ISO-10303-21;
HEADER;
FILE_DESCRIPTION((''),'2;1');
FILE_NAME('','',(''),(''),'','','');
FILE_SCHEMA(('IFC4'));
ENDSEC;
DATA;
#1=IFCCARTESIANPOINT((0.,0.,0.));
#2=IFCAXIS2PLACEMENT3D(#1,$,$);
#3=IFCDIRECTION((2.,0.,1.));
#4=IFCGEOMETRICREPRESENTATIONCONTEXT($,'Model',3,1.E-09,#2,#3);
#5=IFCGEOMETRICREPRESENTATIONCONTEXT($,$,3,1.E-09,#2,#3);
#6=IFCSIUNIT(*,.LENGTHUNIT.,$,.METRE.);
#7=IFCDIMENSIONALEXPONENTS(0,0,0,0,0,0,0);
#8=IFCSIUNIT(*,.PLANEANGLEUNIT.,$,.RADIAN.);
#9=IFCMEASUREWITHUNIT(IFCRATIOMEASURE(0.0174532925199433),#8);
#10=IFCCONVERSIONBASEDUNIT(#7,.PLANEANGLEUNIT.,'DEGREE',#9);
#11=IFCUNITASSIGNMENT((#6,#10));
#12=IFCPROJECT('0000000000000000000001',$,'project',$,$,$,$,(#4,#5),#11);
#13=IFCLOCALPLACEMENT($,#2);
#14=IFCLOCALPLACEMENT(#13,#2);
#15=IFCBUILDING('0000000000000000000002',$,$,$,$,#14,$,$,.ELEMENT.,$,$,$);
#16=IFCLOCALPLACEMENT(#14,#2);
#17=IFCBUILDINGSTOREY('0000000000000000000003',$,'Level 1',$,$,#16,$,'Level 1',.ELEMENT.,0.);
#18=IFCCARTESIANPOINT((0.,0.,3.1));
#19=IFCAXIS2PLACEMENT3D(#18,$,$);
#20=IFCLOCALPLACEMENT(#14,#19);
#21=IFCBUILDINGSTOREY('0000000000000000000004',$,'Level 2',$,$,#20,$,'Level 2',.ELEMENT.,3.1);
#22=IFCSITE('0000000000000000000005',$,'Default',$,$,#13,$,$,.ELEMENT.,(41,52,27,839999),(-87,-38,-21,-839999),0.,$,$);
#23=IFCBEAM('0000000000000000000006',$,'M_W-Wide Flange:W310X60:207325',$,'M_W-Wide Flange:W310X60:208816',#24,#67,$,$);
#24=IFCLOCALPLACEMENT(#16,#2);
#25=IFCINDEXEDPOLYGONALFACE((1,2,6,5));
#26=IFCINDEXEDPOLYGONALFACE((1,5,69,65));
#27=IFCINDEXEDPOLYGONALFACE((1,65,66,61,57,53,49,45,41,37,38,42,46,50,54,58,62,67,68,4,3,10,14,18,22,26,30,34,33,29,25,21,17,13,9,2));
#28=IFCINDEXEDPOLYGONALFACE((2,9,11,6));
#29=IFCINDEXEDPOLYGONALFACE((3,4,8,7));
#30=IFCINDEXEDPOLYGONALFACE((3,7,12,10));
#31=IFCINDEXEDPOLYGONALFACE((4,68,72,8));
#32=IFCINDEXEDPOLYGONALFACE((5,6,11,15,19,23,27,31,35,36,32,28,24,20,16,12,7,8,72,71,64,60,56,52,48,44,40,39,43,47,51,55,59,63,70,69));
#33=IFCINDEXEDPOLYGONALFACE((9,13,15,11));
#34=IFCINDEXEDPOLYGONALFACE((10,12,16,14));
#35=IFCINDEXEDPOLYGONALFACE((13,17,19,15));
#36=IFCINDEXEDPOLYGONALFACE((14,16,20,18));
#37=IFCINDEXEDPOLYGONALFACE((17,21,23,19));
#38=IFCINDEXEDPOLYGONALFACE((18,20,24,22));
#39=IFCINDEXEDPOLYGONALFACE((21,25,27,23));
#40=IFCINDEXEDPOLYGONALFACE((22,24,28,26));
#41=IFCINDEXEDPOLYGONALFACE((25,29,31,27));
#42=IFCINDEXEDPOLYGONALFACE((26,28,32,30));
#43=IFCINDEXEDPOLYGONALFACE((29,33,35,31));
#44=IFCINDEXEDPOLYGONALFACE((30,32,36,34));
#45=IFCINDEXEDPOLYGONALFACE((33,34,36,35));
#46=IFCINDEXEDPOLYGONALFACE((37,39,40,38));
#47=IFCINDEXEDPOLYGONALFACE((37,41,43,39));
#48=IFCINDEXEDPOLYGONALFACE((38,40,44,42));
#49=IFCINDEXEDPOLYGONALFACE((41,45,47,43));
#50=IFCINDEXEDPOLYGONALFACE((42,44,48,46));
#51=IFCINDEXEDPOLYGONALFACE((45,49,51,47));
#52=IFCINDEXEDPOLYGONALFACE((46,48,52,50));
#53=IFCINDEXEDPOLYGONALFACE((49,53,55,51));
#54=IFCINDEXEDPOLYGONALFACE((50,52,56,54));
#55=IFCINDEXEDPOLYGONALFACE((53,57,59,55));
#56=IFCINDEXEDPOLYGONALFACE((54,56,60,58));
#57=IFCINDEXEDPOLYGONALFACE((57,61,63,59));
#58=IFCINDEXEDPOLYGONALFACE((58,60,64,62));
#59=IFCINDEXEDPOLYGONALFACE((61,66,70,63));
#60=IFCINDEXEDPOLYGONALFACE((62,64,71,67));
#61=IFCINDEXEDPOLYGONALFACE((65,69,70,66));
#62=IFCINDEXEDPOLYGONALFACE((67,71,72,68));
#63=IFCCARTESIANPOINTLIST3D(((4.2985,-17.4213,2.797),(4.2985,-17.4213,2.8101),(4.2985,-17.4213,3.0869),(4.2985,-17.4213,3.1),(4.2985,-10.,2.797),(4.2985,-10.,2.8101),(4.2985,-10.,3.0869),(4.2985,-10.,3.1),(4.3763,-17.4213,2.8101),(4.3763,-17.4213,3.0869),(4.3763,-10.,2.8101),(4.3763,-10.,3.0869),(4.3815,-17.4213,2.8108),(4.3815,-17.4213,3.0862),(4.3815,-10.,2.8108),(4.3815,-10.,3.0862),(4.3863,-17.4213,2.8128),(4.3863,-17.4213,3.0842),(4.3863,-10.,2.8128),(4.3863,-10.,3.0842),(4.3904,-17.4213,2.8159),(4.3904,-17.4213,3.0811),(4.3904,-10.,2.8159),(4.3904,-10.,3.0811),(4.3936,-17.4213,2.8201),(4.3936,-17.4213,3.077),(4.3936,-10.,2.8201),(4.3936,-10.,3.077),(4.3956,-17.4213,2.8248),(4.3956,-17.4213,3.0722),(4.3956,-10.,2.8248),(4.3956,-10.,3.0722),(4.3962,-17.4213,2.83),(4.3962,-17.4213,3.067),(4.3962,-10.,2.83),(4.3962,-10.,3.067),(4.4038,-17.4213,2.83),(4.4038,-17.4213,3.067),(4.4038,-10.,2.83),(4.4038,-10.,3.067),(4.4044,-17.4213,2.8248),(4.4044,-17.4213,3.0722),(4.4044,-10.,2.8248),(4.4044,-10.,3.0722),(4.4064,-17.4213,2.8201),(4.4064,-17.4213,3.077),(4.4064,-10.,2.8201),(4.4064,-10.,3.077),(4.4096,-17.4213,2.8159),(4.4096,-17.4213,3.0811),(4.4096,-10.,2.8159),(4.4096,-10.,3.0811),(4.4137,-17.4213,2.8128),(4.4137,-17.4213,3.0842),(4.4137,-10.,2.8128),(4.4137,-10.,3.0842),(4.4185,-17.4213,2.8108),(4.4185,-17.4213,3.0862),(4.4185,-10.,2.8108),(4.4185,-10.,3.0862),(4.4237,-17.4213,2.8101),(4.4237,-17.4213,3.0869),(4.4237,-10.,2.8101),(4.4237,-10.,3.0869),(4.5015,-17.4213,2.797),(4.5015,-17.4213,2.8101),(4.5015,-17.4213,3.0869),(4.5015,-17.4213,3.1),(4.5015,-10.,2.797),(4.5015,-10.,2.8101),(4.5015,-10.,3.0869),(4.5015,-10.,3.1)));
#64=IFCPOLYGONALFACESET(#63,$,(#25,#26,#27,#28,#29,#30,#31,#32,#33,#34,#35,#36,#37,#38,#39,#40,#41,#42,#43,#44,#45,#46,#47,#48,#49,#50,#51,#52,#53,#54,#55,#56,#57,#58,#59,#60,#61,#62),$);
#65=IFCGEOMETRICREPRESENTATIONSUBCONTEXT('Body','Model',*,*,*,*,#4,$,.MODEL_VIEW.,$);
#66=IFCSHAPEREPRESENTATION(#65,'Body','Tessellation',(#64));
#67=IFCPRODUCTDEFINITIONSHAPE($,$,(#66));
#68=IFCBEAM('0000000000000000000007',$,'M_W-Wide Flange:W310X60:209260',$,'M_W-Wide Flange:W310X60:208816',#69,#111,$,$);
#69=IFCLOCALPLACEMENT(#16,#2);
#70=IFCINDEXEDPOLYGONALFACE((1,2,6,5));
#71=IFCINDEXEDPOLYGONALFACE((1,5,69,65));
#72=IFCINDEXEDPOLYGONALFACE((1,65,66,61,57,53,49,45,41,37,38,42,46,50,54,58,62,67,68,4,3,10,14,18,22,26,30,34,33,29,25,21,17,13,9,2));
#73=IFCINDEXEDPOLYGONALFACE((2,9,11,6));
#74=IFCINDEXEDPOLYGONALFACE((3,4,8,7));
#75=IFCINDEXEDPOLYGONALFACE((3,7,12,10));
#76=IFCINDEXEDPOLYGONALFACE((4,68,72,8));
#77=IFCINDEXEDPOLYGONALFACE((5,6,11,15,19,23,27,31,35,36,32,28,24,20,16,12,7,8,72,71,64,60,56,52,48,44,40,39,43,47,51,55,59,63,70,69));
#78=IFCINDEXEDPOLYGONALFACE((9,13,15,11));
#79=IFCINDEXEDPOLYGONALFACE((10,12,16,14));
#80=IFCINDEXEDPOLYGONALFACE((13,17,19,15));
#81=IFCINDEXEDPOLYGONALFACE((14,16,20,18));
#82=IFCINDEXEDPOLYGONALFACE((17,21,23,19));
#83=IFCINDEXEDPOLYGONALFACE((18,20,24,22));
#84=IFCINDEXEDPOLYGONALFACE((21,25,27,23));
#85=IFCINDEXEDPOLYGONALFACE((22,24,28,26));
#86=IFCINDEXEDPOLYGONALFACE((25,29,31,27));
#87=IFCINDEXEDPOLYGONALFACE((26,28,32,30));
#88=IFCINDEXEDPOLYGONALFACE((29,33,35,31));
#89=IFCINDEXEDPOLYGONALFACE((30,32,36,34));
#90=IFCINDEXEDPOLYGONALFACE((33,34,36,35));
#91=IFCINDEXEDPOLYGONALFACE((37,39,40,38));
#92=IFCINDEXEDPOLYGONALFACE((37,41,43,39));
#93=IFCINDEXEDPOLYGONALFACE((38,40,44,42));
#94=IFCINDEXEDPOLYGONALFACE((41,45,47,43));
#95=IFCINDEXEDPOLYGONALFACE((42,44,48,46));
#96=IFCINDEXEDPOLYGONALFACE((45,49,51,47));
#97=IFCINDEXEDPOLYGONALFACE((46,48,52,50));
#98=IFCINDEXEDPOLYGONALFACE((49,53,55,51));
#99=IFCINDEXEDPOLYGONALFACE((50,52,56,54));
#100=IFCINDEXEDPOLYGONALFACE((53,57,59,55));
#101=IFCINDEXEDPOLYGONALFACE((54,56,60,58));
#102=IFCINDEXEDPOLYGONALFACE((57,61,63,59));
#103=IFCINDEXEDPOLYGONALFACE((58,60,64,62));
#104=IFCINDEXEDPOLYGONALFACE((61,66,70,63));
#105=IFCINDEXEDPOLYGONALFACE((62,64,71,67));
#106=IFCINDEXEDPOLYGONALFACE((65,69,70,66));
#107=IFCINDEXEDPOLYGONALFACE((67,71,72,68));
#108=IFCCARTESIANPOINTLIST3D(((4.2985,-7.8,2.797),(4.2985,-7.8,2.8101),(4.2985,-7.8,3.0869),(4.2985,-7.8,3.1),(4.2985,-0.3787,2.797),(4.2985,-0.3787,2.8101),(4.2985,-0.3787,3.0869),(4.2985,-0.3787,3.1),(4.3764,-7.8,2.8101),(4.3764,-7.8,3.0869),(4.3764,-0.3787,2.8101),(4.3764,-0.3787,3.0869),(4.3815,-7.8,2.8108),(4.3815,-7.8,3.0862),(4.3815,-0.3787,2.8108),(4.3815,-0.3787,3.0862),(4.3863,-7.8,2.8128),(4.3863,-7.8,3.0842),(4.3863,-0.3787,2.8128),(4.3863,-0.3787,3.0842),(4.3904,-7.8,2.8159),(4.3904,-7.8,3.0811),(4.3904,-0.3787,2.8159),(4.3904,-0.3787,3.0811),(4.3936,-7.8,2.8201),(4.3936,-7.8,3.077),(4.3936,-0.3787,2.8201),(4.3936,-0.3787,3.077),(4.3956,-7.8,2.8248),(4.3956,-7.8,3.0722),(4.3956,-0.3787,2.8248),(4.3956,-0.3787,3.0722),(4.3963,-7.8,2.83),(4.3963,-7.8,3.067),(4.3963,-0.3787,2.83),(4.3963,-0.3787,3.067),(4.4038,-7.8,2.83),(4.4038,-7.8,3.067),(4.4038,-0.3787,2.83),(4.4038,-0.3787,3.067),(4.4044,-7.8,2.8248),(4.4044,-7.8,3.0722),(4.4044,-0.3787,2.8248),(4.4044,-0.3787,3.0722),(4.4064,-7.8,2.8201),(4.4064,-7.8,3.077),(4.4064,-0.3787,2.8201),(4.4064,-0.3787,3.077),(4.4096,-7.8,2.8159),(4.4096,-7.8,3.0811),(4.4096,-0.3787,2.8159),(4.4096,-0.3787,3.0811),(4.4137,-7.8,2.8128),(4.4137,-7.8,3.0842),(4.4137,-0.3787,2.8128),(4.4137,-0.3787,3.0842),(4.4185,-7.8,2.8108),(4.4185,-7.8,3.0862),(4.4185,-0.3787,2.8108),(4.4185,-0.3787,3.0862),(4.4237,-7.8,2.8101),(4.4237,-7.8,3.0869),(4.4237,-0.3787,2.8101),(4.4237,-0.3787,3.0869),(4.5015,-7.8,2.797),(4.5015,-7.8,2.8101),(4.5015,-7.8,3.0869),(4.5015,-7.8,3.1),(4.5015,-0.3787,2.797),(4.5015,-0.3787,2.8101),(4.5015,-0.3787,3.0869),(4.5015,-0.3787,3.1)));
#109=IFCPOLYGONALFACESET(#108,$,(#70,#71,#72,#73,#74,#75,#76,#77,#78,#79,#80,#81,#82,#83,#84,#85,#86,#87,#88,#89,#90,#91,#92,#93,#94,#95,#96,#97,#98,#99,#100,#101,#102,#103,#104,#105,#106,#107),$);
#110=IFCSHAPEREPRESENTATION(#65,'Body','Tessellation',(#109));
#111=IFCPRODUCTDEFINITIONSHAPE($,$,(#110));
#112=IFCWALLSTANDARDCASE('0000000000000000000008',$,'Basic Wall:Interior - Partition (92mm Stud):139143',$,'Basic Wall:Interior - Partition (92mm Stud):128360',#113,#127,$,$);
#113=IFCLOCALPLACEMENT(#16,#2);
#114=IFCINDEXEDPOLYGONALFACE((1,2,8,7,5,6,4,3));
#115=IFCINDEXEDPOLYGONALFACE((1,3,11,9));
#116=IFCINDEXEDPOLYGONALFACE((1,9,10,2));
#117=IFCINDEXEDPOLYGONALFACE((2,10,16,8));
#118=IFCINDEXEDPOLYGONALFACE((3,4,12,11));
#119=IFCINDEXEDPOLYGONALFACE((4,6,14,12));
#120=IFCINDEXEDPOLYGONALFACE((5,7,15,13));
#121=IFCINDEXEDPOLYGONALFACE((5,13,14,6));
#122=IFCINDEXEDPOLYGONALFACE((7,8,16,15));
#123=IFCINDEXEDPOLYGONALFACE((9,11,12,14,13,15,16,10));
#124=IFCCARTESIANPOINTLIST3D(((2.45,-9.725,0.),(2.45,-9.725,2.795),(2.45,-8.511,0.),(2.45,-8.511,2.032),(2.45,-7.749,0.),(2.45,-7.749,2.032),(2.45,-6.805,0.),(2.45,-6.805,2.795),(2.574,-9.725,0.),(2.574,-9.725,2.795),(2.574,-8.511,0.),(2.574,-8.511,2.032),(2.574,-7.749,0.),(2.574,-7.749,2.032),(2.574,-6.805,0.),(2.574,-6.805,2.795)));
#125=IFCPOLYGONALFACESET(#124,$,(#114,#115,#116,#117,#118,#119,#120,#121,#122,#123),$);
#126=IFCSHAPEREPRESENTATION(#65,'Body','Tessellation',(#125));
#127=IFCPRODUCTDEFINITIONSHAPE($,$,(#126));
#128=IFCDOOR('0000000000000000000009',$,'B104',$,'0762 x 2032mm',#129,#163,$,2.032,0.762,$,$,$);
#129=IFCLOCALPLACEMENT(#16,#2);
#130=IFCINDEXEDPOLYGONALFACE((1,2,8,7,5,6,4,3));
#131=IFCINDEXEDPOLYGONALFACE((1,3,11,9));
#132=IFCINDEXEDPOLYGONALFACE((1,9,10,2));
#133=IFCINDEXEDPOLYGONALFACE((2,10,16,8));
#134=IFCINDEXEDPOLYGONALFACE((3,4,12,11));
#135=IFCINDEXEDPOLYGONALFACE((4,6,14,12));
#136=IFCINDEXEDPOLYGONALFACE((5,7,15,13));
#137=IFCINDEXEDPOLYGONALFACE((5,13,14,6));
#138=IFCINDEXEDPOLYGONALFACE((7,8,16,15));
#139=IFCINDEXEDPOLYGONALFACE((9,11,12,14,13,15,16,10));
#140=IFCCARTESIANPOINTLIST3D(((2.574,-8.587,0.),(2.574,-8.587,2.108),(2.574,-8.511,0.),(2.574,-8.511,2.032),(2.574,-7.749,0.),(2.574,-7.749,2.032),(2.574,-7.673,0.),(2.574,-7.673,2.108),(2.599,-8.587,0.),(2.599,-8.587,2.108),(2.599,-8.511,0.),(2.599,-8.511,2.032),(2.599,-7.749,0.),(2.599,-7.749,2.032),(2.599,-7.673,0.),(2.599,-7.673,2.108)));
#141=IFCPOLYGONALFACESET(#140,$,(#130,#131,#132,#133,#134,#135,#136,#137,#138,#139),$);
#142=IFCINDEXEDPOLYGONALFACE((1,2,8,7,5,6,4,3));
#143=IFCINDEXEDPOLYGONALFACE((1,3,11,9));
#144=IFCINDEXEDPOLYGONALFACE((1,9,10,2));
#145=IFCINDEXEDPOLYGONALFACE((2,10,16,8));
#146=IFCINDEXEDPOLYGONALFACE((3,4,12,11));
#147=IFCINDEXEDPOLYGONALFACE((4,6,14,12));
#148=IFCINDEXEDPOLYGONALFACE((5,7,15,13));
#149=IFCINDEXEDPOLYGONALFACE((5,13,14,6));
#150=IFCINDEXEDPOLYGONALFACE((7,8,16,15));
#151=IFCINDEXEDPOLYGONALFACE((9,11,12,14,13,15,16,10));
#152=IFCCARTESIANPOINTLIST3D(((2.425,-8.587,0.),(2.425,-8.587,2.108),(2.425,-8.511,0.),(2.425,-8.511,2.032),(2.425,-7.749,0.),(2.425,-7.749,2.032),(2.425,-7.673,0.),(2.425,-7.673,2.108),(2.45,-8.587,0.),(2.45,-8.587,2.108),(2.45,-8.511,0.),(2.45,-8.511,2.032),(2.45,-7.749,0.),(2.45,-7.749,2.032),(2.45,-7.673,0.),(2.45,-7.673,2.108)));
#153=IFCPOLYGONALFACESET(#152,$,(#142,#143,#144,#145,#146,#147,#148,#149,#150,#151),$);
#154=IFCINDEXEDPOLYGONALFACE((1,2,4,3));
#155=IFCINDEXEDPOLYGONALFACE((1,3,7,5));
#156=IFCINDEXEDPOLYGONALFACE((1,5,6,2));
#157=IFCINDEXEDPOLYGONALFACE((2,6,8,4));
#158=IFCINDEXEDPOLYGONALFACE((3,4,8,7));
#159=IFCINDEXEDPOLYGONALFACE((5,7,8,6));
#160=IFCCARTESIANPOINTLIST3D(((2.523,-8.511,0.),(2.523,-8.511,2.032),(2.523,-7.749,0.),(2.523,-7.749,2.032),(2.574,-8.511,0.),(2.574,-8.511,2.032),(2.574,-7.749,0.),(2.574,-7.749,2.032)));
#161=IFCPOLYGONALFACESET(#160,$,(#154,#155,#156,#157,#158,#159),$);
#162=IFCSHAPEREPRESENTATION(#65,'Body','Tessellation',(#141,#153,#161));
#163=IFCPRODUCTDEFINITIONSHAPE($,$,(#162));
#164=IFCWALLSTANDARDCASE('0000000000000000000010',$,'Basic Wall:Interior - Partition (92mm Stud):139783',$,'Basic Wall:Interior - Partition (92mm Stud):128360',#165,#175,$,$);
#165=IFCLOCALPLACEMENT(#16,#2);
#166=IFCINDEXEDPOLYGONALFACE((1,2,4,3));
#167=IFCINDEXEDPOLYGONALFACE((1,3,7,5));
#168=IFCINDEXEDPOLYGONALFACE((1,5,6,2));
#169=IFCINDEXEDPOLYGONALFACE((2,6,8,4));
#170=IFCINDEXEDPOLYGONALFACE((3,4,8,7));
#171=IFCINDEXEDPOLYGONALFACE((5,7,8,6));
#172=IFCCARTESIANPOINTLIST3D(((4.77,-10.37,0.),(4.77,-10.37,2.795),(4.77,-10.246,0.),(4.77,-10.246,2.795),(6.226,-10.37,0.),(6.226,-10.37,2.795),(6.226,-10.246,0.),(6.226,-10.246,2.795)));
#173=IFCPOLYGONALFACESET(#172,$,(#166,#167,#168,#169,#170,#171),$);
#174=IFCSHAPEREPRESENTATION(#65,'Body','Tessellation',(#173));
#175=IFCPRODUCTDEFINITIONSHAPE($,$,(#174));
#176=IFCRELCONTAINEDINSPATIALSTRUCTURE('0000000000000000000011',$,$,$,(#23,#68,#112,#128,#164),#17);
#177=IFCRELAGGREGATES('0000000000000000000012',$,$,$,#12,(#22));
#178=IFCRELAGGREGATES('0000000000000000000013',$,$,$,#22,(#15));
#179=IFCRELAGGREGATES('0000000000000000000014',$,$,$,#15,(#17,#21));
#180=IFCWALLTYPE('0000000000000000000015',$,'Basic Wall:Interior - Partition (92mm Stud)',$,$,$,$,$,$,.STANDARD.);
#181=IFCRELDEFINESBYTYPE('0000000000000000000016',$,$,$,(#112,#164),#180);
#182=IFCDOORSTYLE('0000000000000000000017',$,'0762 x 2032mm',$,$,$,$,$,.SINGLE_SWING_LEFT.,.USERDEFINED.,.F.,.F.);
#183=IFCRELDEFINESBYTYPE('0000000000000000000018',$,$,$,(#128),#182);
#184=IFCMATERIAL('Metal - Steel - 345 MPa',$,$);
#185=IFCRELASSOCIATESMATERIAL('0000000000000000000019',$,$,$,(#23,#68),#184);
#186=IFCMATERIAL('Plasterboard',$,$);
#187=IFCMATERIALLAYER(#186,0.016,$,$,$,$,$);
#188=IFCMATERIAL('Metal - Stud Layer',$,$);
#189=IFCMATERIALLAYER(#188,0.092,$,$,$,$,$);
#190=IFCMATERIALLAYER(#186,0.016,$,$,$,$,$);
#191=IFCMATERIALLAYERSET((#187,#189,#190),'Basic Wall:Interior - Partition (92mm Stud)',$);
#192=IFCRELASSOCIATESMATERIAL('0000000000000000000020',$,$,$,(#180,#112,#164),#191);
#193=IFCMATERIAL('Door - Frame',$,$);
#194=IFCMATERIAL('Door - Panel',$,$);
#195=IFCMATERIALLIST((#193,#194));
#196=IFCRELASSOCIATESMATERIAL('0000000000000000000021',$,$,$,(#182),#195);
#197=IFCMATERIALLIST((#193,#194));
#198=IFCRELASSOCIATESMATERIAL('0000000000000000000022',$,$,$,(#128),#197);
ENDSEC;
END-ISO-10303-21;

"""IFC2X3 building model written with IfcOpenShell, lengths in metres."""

from ifc_helpers import new_model, entity, si_unit, converted_unit, direction, frame, frame_2d, origin, place, context, subcontext, project, spatial, polyline, rectangle, i_section, outline, extrude, source, transform, mapped, material, material_list, layer, layer_set, layer_usage, type_object, type_shapes, element, fill, save


model = new_model("IFC2X3")

# Units and contexts
model_context = context("Model", 3, precision=1e-09, world=origin(), true_north=direction((2.0, 0.0, 1.0)))
context_of_model = context(None, 3, precision=1e-09, world=origin(), true_north=direction((2.0, 0.0, 1.0)))
body_context = subcontext(model_context, "Body", "Model", "MODEL_VIEW")
ifc_project = project(units=[si_unit("LENGTHUNIT", "METRE"), converted_unit("PLANEANGLEUNIT", "DEGREE", entity("IfcRatioMeasure", 0.0174532925199433), si_unit("PLANEANGLEUNIT", "RADIAN"), dimensions=[0, 0, 0, 0, 0, 0, 0])], contexts=[model_context, context_of_model])

# Site, building, storey
site_placement = place(None, origin())
site = spatial("IfcSite", under=ifc_project, at=site_placement, Name="Default", CompositionType="ELEMENT", RefLatitude=(41, 52, 27, 839999), RefLongitude=(-87, -38, -21, -839999), RefElevation=0.0)
building_placement = place(site_placement, origin())
building = spatial("IfcBuilding", under=site, at=building_placement, CompositionType="ELEMENT")
storey_1_placement = place(building_placement, origin())
storey_1 = spatial("IfcBuildingStorey", under=building, at=storey_1_placement, Name="Level 1", LongName="Level 1", CompositionType="ELEMENT", Elevation=0.0)

# Beams
ifc_material_1 = material(Name="Metal - Steel - 345 MPa")
beam_1_placement = place(storey_1_placement, frame((4.4, -10.0, 3.1), z_axis=(0.0, 0.0, 1.0), x_axis=(0.0, -1.0, 0.0)))
element("IfcBeam", 1, at=beam_1_placement, inside=storey_1, material=ifc_material_1, Name="M_W-Wide Flange:W310X60:207325", ObjectType="M_W-Wide Flange:W310X60:208816", context=body_context, shape_type="SweptSolid", body=[
    extrude(i_section(OverallWidth=0.203, OverallDepth=0.303, WebThickness=0.0075, FlangeThickness=0.0131, FilletRadius=0.0199, at=frame_2d((0.0, 0.0), x_axis=(0.0, 1.0))), frame((0.0, 0.0, -0.1515), z_axis=(1.0, 0.0, 0.0), x_axis=(0.0, 0.0, -1.0)), (0.0, 0.0, 1.0), 7.4213),
])
beam_2_placement = place(storey_1_placement, frame((4.4, -7.8, 3.1), z_axis=(0.0, 0.0, 1.0), x_axis=(0.0, 1.0, 0.0)))
element("IfcBeam", 2, at=beam_2_placement, inside=storey_1, material=ifc_material_1, Name="M_W-Wide Flange:W310X60:209260", ObjectType="M_W-Wide Flange:W310X60:208816", context=body_context, shape_type="SweptSolid", body=[
    extrude(i_section(OverallWidth=0.203, OverallDepth=0.303, WebThickness=0.0075, FlangeThickness=0.0131, FilletRadius=0.0199, at=frame_2d((0.0, 0.0), x_axis=(0.0, 1.0))), frame((0.0, 0.0, -0.1515), z_axis=(1.0, 0.0, 0.0), x_axis=(0.0, 0.0, -1.0)), (0.0, 0.0, 1.0), 7.4213),
])

# Wall, opening, door
ifc_material_2 = material(Name="Plasterboard")
ifc_layer_1 = layer(ifc_material_2, 0.016)
ifc_material_3 = material(Name="Metal - Stud Layer")
ifc_layer_2 = layer(ifc_material_3, 0.092)
ifc_layer_3 = layer(ifc_material_2, 0.016)
ifc_layer_set_1 = layer_set([ifc_layer_1, ifc_layer_2, ifc_layer_3], Name="Basic Wall:Interior - Partition (92mm Stud)")
ifc_layer_usage_1 = layer_usage(ifc_layer_set_1, "AXIS2", "NEGATIVE", 0.062)
wall_type_1 = type_object("IfcWallType", Name="Basic Wall:Interior - Partition (92mm Stud)", PredefinedType="STANDARD", material=ifc_layer_set_1)
wall_1_placement = place(storey_1_placement, frame((2.512, -6.805, 0.0), z_axis=(0.0, 0.0, 1.0), x_axis=(0.0, -1.0, 0.0)))
wall_1 = element("IfcWallStandardCase", 3, at=wall_1_placement, inside=storey_1, type_object=wall_type_1, material=ifc_layer_usage_1, Name="Basic Wall:Interior - Partition (92mm Stud):139143", ObjectType="Basic Wall:Interior - Partition (92mm Stud):128360", context=body_context, shape_type="SweptSolid", body=[
    extrude(rectangle(XDim=2.92, YDim=0.124, at=frame_2d((1.46, 0.0), x_axis=(-1.0, 0.0))), origin(), (0.0, 0.0, 1.0), 2.795),
])
opening_1_placement = place(wall_1_placement, frame((0.944, -0.062, 0.0)))
opening_1 = element("IfcOpeningElement", 4, at=opening_1_placement, cuts=wall_1, ObjectType="Opening", context=body_context, shape_type="SweptSolid", body=[
    extrude(rectangle(XDim=0.762, YDim=2.032, at=frame_2d((1.016, 0.381), x_axis=(0.0, -1.0))), frame((0.0, 0.0, 0.0), z_axis=(0.0, 1.0, 0.0), x_axis=(0.0, 0.0, 1.0)), (0.0, 0.0, 1.0), 0.124),
])
ifc_material_4 = material(Name="Door - Frame")
ifc_material_5 = material(Name="Door - Panel")
ifc_material_list_1 = material_list([ifc_material_4, ifc_material_5])
ifc_material_list_2 = material_list([ifc_material_4, ifc_material_5])
door_style_1 = type_object("IfcDoorStyle", Name="0762 x 2032mm", ConstructionType="USERDEFINED", OperationType="SINGLE_SWING_LEFT", ParameterTakesPrecedence=False, Sizeable=False, material=ifc_material_list_2)
shared_shape_1 = source(origin(), body_context, "Body", "SweptSolid", [
    extrude(outline(polyline([(-0.457, -1.073), (0.457, -1.073), (0.457, 1.035), (0.381, 1.035), (0.381, -0.997), (-0.381, -0.997), (-0.381, 1.035), (-0.457, 1.035), (-0.457, -1.073)])), frame((0.381, 0.149, 1.035), z_axis=(0.0, -1.0, 0.0), x_axis=(-1.0, 0.0, 0.0)), (0.0, 0.0, 1.0), 0.025),
    extrude(outline(polyline([(-1.073, -0.457), (1.035, -0.457), (1.035, -0.381), (-0.997, -0.381), (-0.997, 0.381), (1.035, 0.381), (1.035, 0.457), (-1.073, 0.457), (-1.073, -0.457)])), frame((0.381, 0.0, 1.035), z_axis=(0.0, -1.0, 0.0), x_axis=(0.0, 0.0, -1.0)), (0.0, 0.0, 1.0), 0.025),
    extrude(rectangle(XDim=0.762, YDim=0.051, at=frame_2d((0.0, 0.0), x_axis=(1.0, 0.0))), frame((0.381, 0.0985, 0.0)), (0.0, 0.0, 1.0), 2.032),
])
type_shapes(door_style_1, [shared_shape_1])
door_1_placement = place(opening_1_placement, origin())
door_1 = element("IfcDoor", 5, at=door_1_placement, inside=storey_1, type_object=door_style_1, material=ifc_material_list_1, Name="B104", ObjectType="0762 x 2032mm", OverallHeight=2.032, OverallWidth=0.762, context=body_context, shape_type="MappedRepresentation", body=[
    mapped(shared_shape_1, transform((0.0, 0.0, 0.0), scale=1.0)),
])
fill(opening_1, door_1)

# Wall
ifc_layer_usage_2 = layer_usage(ifc_layer_set_1, "AXIS2", "NEGATIVE", 0.062)
wall_2_placement = place(storey_1_placement, frame((4.77, -10.308, 0.0)))
element("IfcWallStandardCase", 6, at=wall_2_placement, inside=storey_1, type_object=wall_type_1, material=ifc_layer_usage_2, Name="Basic Wall:Interior - Partition (92mm Stud):139783", ObjectType="Basic Wall:Interior - Partition (92mm Stud):128360", context=body_context, shape_type="SweptSolid", body=[
    extrude(rectangle(XDim=1.456, YDim=0.124, at=frame_2d((0.728, 0.0), x_axis=(-1.0, 0.0))), origin(), (0.0, 0.0, 1.0), 2.795),
])

# Shared definitions
storey_2_placement = place(building_placement, frame((0.0, 0.0, 3.1)))
storey_2 = spatial("IfcBuildingStorey", under=building, at=storey_2_placement, Name="Level 2", LongName="Level 2", CompositionType="ELEMENT", Elevation=3.1)

save(model, "model.ifc")
